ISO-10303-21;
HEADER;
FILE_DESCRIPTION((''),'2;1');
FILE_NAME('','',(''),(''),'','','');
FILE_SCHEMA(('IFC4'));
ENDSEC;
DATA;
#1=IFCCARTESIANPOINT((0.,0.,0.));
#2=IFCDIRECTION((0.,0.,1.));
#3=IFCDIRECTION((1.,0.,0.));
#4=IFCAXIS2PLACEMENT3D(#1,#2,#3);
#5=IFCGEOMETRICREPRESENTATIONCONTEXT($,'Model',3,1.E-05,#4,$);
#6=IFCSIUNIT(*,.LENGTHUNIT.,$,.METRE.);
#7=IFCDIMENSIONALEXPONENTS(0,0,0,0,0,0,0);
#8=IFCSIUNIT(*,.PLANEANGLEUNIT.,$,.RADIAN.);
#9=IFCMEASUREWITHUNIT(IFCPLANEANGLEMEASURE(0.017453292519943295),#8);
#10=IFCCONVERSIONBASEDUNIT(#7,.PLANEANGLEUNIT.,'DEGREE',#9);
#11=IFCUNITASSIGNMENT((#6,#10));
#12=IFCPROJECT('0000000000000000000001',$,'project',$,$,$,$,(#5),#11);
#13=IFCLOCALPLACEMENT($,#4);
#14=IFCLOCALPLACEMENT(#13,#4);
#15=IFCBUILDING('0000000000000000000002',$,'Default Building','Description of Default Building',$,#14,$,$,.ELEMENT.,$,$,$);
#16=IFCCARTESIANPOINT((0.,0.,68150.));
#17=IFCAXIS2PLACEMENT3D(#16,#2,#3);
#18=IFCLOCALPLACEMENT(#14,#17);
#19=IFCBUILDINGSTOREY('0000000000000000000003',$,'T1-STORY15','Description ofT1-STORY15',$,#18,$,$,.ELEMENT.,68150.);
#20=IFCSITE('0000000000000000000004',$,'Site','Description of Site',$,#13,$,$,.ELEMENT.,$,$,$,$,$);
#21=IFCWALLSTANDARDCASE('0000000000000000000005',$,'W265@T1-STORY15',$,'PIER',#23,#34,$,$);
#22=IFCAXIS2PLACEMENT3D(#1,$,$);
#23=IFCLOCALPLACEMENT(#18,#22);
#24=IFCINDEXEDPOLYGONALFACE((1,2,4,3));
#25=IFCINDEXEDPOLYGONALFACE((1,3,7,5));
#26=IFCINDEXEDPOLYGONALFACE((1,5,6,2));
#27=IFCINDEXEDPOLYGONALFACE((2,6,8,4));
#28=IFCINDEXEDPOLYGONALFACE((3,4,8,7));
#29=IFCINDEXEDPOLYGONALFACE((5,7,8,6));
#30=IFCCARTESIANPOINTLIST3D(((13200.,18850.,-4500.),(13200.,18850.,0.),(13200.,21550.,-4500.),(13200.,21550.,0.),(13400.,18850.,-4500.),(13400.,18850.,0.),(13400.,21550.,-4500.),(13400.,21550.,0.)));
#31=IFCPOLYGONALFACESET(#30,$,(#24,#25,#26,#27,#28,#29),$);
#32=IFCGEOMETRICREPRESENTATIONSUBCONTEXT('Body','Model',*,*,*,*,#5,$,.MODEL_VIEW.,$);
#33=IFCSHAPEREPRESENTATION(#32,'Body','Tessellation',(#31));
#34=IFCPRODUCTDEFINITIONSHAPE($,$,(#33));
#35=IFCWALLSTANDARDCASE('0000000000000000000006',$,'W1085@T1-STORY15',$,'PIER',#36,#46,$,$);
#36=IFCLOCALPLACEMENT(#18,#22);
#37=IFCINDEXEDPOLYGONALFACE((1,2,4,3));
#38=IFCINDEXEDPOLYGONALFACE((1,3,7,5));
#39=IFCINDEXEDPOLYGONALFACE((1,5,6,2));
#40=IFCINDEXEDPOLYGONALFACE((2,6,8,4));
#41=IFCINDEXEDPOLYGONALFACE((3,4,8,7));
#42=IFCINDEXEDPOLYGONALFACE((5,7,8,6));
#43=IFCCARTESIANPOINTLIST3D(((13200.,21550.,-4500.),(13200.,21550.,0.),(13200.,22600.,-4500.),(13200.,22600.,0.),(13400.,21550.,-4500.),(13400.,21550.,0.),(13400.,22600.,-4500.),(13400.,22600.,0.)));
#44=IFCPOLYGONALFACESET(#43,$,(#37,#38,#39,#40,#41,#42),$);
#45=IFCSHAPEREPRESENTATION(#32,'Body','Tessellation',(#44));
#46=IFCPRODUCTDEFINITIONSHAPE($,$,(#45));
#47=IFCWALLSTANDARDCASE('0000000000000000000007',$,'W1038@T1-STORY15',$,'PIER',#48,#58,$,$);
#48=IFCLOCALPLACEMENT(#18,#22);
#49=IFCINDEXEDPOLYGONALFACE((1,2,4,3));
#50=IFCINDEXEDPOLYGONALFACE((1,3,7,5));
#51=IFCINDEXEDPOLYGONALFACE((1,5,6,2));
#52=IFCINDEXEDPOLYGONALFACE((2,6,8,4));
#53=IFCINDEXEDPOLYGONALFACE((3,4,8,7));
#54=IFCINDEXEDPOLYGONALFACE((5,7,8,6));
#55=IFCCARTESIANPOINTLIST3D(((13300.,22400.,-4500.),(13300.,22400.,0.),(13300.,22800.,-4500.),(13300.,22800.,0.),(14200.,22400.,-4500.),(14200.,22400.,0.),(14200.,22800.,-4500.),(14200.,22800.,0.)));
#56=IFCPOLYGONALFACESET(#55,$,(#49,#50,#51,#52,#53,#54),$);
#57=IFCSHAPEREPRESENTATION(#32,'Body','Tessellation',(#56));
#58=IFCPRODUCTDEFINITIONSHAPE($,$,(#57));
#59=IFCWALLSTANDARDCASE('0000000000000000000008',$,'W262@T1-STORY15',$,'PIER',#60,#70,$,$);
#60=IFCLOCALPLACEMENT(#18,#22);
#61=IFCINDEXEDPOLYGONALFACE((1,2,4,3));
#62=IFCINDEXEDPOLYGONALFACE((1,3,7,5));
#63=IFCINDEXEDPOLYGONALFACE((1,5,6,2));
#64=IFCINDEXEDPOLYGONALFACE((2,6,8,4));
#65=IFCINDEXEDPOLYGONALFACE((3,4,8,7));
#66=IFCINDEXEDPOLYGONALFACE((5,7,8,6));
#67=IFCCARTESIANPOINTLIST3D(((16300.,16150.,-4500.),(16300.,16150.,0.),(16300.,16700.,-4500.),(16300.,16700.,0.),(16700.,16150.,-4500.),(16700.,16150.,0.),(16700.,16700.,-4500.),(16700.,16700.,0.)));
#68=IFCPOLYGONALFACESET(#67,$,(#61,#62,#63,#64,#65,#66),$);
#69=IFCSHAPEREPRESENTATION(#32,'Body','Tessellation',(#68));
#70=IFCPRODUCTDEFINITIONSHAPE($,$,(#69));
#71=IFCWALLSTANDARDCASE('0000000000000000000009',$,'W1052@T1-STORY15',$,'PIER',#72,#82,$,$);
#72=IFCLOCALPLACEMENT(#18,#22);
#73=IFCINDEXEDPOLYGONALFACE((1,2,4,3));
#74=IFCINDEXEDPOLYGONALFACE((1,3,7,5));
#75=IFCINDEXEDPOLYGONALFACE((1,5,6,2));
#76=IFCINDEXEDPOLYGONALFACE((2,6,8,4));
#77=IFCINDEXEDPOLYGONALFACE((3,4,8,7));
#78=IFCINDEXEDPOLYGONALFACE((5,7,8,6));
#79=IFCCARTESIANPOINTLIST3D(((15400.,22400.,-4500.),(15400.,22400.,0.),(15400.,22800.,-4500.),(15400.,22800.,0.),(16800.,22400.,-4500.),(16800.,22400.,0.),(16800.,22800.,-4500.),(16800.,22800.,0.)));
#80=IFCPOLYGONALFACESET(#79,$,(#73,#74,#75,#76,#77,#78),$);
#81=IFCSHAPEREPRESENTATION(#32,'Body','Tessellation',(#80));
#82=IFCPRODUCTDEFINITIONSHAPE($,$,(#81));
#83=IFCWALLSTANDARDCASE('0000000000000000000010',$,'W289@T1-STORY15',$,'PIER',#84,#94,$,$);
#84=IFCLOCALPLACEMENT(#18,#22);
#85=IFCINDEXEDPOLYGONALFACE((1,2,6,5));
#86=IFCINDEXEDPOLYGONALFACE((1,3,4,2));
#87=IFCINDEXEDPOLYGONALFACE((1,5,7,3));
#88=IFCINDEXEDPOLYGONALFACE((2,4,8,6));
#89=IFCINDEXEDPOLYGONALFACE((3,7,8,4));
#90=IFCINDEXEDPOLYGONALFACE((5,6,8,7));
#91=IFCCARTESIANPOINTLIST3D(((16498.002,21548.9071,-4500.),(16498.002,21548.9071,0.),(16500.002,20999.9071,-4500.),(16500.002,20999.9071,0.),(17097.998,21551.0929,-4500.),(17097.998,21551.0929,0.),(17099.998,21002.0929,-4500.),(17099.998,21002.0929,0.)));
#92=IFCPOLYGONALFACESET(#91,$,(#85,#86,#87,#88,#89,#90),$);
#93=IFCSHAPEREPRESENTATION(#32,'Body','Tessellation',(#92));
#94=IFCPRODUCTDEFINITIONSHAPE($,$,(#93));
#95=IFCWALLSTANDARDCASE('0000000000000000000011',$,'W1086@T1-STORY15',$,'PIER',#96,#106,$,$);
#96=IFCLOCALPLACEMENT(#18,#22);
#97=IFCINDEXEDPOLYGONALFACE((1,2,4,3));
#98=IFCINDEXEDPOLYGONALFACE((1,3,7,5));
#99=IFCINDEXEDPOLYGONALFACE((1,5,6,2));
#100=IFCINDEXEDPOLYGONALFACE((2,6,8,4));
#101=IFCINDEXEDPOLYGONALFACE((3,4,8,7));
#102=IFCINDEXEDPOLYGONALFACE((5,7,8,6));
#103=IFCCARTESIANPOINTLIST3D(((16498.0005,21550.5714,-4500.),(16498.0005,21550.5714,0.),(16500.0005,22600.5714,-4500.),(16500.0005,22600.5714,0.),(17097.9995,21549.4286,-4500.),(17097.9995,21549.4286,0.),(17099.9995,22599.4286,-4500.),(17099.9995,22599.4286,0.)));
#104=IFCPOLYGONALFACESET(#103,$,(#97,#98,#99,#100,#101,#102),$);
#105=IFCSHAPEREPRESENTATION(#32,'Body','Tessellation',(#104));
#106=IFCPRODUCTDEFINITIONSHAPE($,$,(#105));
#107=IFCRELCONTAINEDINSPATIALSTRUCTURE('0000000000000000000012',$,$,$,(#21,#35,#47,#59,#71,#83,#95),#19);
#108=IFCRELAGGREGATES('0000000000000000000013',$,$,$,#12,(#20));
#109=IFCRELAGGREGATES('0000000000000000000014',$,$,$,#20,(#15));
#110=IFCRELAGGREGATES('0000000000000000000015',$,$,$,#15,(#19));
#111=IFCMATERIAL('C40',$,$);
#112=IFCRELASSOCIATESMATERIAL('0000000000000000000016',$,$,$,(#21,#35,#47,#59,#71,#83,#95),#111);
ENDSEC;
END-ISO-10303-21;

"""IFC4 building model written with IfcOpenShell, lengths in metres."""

from ifc_helpers import new_model, entity, si_unit, converted_unit, frame, origin_with_axes, place, context, subcontext, project, spatial, indexed_curve, outline, extrude, material, element, save


model = new_model("IFC4")

# Units and contexts
model_context = context("Model", 3, precision=1e-05, world=origin_with_axes())
body_context = subcontext(model_context, "Body", "Model", "MODEL_VIEW")
ifc_project = project(units=[si_unit("LENGTHUNIT", "METRE"), converted_unit("PLANEANGLEUNIT", "DEGREE", entity("IfcPlaneAngleMeasure", 0.017453292519943295), si_unit("PLANEANGLEUNIT", "RADIAN"), dimensions=[0, 0, 0, 0, 0, 0, 0])], contexts=[model_context])

# Site, building, storey
site_placement = place(None, origin_with_axes())
site = spatial("IfcSite", under=ifc_project, at=site_placement, Name="Site", Description="Description of Site", CompositionType="ELEMENT")
building_placement = place(site_placement, origin_with_axes())
building = spatial("IfcBuilding", under=site, at=building_placement, Name="Default Building", Description="Description of Default Building", CompositionType="ELEMENT")
storey_placement = place(building_placement, frame((0.0, 0.0, 68150.0), z_axis=(0.0, 0.0, 1.0), x_axis=(1.0, 0.0, 0.0)))
storey = spatial("IfcBuildingStorey", under=building, at=storey_placement, Name="T1-STORY15", Description="Description ofT1-STORY15", CompositionType="ELEMENT", Elevation=68150.0)

# Walls
ifc_material_1 = material(Name="C40")
wall_1_placement = place(storey_placement, frame((13300.0, 18850.0, -4500.0), z_axis=(0.0, 0.0, 1.0), x_axis=(0.0, 1.0, 0.0)))
element("IfcWallStandardCase", 1, at=wall_1_placement, inside=storey, material=ifc_material_1, Name="W265@T1-STORY15", ObjectType="PIER", context=body_context, shape_type="SweptSolid", body=[
    extrude(outline(indexed_curve([(0.0, -100.0), (0.0, 100.0), (2700.0, 100.0), (2700.0, -100.0), (0.0, -100.0)], self_intersect=False)), origin_with_axes(), (0.0, 0.0, 1.0), 4500.0),
])
wall_2_placement = place(storey_placement, frame((13300.0, 21550.0, -4500.0), z_axis=(0.0, 0.0, 1.0), x_axis=(0.0, 1.0, 0.0)))
element("IfcWallStandardCase", 2, at=wall_2_placement, inside=storey, material=ifc_material_1, Name="W1085@T1-STORY15", ObjectType="PIER", context=body_context, shape_type="SweptSolid", body=[
    extrude(outline(indexed_curve([(0.0, -100.0), (0.0, 100.0), (1050.0, 100.0), (1050.0, -100.0), (0.0, -100.0)], self_intersect=False)), origin_with_axes(), (0.0, 0.0, 1.0), 4500.0),
])
wall_3_placement = place(storey_placement, frame((13300.0, 22600.0, -4500.0), z_axis=(0.0, 0.0, 1.0), x_axis=(1.0, 0.0, 0.0)))
element("IfcWallStandardCase", 3, at=wall_3_placement, inside=storey, material=ifc_material_1, Name="W1038@T1-STORY15", ObjectType="PIER", context=body_context, shape_type="SweptSolid", body=[
    extrude(outline(indexed_curve([(0.0, -200.0), (0.0, 200.0), (900.0, 200.0), (900.0, -200.0), (0.0, -200.0)], self_intersect=False)), origin_with_axes(), (0.0, 0.0, 1.0), 4500.0),
])
wall_4_placement = place(storey_placement, frame((16500.0, 16150.0, -4500.0), z_axis=(0.0, 0.0, 1.0), x_axis=(0.0, 1.0, 0.0)))
element("IfcWallStandardCase", 4, at=wall_4_placement, inside=storey, material=ifc_material_1, Name="W262@T1-STORY15", ObjectType="PIER", context=body_context, shape_type="SweptSolid", body=[
    extrude(outline(indexed_curve([(0.0, -200.0), (0.0, 200.0), (550.0, 200.0), (550.0, -200.0), (0.0, -200.0)], self_intersect=False)), origin_with_axes(), (0.0, 0.0, 1.0), 4500.0),
])
wall_5_placement = place(storey_placement, frame((15400.0, 22600.0, -4500.0), z_axis=(0.0, 0.0, 1.0), x_axis=(1.0, 0.0, 0.0)))
element("IfcWallStandardCase", 5, at=wall_5_placement, inside=storey, material=ifc_material_1, Name="W1052@T1-STORY15", ObjectType="PIER", context=body_context, shape_type="SweptSolid", body=[
    extrude(outline(indexed_curve([(0.0, -200.0), (0.0, 200.0), (1400.0, 200.0), (1400.0, -200.0), (0.0, -200.0)], self_intersect=False)), origin_with_axes(), (0.0, 0.0, 1.0), 4500.0),
])
wall_6_placement = place(storey_placement, frame((16800.0, 21001.0, -4500.0), z_axis=(0.0, 0.0, 1.0), x_axis=(-0.003643, 0.999993, 0.0)))
element("IfcWallStandardCase", 6, at=wall_6_placement, inside=storey, material=ifc_material_1, Name="W289@T1-STORY15", ObjectType="PIER", context=body_context, shape_type="SweptSolid", body=[
    extrude(outline(indexed_curve([(0.0, -300.0), (0.0, 300.0), (549.0036, 300.0), (549.0036, -300.0), (0.0, -300.0)], self_intersect=False)), origin_with_axes(), (0.0, 0.0, 1.0), 4500.0),
])
wall_7_placement = place(storey_placement, frame((16798.0, 21550.0, -4500.0), z_axis=(0.0, 0.0, 1.0), x_axis=(0.001905, 0.999998, 0.0)))
element("IfcWallStandardCase", 7, at=wall_7_placement, inside=storey, material=ifc_material_1, Name="W1086@T1-STORY15", ObjectType="PIER", context=body_context, shape_type="SweptSolid", body=[
    extrude(outline(indexed_curve([(0.0, -300.0), (0.0, 300.0), (1050.0019, 300.0), (1050.0019, -300.0), (0.0, -300.0)], self_intersect=False)), origin_with_axes(), (0.0, 0.0, 1.0), 4500.0),
])

save(model, "model.ifc")
